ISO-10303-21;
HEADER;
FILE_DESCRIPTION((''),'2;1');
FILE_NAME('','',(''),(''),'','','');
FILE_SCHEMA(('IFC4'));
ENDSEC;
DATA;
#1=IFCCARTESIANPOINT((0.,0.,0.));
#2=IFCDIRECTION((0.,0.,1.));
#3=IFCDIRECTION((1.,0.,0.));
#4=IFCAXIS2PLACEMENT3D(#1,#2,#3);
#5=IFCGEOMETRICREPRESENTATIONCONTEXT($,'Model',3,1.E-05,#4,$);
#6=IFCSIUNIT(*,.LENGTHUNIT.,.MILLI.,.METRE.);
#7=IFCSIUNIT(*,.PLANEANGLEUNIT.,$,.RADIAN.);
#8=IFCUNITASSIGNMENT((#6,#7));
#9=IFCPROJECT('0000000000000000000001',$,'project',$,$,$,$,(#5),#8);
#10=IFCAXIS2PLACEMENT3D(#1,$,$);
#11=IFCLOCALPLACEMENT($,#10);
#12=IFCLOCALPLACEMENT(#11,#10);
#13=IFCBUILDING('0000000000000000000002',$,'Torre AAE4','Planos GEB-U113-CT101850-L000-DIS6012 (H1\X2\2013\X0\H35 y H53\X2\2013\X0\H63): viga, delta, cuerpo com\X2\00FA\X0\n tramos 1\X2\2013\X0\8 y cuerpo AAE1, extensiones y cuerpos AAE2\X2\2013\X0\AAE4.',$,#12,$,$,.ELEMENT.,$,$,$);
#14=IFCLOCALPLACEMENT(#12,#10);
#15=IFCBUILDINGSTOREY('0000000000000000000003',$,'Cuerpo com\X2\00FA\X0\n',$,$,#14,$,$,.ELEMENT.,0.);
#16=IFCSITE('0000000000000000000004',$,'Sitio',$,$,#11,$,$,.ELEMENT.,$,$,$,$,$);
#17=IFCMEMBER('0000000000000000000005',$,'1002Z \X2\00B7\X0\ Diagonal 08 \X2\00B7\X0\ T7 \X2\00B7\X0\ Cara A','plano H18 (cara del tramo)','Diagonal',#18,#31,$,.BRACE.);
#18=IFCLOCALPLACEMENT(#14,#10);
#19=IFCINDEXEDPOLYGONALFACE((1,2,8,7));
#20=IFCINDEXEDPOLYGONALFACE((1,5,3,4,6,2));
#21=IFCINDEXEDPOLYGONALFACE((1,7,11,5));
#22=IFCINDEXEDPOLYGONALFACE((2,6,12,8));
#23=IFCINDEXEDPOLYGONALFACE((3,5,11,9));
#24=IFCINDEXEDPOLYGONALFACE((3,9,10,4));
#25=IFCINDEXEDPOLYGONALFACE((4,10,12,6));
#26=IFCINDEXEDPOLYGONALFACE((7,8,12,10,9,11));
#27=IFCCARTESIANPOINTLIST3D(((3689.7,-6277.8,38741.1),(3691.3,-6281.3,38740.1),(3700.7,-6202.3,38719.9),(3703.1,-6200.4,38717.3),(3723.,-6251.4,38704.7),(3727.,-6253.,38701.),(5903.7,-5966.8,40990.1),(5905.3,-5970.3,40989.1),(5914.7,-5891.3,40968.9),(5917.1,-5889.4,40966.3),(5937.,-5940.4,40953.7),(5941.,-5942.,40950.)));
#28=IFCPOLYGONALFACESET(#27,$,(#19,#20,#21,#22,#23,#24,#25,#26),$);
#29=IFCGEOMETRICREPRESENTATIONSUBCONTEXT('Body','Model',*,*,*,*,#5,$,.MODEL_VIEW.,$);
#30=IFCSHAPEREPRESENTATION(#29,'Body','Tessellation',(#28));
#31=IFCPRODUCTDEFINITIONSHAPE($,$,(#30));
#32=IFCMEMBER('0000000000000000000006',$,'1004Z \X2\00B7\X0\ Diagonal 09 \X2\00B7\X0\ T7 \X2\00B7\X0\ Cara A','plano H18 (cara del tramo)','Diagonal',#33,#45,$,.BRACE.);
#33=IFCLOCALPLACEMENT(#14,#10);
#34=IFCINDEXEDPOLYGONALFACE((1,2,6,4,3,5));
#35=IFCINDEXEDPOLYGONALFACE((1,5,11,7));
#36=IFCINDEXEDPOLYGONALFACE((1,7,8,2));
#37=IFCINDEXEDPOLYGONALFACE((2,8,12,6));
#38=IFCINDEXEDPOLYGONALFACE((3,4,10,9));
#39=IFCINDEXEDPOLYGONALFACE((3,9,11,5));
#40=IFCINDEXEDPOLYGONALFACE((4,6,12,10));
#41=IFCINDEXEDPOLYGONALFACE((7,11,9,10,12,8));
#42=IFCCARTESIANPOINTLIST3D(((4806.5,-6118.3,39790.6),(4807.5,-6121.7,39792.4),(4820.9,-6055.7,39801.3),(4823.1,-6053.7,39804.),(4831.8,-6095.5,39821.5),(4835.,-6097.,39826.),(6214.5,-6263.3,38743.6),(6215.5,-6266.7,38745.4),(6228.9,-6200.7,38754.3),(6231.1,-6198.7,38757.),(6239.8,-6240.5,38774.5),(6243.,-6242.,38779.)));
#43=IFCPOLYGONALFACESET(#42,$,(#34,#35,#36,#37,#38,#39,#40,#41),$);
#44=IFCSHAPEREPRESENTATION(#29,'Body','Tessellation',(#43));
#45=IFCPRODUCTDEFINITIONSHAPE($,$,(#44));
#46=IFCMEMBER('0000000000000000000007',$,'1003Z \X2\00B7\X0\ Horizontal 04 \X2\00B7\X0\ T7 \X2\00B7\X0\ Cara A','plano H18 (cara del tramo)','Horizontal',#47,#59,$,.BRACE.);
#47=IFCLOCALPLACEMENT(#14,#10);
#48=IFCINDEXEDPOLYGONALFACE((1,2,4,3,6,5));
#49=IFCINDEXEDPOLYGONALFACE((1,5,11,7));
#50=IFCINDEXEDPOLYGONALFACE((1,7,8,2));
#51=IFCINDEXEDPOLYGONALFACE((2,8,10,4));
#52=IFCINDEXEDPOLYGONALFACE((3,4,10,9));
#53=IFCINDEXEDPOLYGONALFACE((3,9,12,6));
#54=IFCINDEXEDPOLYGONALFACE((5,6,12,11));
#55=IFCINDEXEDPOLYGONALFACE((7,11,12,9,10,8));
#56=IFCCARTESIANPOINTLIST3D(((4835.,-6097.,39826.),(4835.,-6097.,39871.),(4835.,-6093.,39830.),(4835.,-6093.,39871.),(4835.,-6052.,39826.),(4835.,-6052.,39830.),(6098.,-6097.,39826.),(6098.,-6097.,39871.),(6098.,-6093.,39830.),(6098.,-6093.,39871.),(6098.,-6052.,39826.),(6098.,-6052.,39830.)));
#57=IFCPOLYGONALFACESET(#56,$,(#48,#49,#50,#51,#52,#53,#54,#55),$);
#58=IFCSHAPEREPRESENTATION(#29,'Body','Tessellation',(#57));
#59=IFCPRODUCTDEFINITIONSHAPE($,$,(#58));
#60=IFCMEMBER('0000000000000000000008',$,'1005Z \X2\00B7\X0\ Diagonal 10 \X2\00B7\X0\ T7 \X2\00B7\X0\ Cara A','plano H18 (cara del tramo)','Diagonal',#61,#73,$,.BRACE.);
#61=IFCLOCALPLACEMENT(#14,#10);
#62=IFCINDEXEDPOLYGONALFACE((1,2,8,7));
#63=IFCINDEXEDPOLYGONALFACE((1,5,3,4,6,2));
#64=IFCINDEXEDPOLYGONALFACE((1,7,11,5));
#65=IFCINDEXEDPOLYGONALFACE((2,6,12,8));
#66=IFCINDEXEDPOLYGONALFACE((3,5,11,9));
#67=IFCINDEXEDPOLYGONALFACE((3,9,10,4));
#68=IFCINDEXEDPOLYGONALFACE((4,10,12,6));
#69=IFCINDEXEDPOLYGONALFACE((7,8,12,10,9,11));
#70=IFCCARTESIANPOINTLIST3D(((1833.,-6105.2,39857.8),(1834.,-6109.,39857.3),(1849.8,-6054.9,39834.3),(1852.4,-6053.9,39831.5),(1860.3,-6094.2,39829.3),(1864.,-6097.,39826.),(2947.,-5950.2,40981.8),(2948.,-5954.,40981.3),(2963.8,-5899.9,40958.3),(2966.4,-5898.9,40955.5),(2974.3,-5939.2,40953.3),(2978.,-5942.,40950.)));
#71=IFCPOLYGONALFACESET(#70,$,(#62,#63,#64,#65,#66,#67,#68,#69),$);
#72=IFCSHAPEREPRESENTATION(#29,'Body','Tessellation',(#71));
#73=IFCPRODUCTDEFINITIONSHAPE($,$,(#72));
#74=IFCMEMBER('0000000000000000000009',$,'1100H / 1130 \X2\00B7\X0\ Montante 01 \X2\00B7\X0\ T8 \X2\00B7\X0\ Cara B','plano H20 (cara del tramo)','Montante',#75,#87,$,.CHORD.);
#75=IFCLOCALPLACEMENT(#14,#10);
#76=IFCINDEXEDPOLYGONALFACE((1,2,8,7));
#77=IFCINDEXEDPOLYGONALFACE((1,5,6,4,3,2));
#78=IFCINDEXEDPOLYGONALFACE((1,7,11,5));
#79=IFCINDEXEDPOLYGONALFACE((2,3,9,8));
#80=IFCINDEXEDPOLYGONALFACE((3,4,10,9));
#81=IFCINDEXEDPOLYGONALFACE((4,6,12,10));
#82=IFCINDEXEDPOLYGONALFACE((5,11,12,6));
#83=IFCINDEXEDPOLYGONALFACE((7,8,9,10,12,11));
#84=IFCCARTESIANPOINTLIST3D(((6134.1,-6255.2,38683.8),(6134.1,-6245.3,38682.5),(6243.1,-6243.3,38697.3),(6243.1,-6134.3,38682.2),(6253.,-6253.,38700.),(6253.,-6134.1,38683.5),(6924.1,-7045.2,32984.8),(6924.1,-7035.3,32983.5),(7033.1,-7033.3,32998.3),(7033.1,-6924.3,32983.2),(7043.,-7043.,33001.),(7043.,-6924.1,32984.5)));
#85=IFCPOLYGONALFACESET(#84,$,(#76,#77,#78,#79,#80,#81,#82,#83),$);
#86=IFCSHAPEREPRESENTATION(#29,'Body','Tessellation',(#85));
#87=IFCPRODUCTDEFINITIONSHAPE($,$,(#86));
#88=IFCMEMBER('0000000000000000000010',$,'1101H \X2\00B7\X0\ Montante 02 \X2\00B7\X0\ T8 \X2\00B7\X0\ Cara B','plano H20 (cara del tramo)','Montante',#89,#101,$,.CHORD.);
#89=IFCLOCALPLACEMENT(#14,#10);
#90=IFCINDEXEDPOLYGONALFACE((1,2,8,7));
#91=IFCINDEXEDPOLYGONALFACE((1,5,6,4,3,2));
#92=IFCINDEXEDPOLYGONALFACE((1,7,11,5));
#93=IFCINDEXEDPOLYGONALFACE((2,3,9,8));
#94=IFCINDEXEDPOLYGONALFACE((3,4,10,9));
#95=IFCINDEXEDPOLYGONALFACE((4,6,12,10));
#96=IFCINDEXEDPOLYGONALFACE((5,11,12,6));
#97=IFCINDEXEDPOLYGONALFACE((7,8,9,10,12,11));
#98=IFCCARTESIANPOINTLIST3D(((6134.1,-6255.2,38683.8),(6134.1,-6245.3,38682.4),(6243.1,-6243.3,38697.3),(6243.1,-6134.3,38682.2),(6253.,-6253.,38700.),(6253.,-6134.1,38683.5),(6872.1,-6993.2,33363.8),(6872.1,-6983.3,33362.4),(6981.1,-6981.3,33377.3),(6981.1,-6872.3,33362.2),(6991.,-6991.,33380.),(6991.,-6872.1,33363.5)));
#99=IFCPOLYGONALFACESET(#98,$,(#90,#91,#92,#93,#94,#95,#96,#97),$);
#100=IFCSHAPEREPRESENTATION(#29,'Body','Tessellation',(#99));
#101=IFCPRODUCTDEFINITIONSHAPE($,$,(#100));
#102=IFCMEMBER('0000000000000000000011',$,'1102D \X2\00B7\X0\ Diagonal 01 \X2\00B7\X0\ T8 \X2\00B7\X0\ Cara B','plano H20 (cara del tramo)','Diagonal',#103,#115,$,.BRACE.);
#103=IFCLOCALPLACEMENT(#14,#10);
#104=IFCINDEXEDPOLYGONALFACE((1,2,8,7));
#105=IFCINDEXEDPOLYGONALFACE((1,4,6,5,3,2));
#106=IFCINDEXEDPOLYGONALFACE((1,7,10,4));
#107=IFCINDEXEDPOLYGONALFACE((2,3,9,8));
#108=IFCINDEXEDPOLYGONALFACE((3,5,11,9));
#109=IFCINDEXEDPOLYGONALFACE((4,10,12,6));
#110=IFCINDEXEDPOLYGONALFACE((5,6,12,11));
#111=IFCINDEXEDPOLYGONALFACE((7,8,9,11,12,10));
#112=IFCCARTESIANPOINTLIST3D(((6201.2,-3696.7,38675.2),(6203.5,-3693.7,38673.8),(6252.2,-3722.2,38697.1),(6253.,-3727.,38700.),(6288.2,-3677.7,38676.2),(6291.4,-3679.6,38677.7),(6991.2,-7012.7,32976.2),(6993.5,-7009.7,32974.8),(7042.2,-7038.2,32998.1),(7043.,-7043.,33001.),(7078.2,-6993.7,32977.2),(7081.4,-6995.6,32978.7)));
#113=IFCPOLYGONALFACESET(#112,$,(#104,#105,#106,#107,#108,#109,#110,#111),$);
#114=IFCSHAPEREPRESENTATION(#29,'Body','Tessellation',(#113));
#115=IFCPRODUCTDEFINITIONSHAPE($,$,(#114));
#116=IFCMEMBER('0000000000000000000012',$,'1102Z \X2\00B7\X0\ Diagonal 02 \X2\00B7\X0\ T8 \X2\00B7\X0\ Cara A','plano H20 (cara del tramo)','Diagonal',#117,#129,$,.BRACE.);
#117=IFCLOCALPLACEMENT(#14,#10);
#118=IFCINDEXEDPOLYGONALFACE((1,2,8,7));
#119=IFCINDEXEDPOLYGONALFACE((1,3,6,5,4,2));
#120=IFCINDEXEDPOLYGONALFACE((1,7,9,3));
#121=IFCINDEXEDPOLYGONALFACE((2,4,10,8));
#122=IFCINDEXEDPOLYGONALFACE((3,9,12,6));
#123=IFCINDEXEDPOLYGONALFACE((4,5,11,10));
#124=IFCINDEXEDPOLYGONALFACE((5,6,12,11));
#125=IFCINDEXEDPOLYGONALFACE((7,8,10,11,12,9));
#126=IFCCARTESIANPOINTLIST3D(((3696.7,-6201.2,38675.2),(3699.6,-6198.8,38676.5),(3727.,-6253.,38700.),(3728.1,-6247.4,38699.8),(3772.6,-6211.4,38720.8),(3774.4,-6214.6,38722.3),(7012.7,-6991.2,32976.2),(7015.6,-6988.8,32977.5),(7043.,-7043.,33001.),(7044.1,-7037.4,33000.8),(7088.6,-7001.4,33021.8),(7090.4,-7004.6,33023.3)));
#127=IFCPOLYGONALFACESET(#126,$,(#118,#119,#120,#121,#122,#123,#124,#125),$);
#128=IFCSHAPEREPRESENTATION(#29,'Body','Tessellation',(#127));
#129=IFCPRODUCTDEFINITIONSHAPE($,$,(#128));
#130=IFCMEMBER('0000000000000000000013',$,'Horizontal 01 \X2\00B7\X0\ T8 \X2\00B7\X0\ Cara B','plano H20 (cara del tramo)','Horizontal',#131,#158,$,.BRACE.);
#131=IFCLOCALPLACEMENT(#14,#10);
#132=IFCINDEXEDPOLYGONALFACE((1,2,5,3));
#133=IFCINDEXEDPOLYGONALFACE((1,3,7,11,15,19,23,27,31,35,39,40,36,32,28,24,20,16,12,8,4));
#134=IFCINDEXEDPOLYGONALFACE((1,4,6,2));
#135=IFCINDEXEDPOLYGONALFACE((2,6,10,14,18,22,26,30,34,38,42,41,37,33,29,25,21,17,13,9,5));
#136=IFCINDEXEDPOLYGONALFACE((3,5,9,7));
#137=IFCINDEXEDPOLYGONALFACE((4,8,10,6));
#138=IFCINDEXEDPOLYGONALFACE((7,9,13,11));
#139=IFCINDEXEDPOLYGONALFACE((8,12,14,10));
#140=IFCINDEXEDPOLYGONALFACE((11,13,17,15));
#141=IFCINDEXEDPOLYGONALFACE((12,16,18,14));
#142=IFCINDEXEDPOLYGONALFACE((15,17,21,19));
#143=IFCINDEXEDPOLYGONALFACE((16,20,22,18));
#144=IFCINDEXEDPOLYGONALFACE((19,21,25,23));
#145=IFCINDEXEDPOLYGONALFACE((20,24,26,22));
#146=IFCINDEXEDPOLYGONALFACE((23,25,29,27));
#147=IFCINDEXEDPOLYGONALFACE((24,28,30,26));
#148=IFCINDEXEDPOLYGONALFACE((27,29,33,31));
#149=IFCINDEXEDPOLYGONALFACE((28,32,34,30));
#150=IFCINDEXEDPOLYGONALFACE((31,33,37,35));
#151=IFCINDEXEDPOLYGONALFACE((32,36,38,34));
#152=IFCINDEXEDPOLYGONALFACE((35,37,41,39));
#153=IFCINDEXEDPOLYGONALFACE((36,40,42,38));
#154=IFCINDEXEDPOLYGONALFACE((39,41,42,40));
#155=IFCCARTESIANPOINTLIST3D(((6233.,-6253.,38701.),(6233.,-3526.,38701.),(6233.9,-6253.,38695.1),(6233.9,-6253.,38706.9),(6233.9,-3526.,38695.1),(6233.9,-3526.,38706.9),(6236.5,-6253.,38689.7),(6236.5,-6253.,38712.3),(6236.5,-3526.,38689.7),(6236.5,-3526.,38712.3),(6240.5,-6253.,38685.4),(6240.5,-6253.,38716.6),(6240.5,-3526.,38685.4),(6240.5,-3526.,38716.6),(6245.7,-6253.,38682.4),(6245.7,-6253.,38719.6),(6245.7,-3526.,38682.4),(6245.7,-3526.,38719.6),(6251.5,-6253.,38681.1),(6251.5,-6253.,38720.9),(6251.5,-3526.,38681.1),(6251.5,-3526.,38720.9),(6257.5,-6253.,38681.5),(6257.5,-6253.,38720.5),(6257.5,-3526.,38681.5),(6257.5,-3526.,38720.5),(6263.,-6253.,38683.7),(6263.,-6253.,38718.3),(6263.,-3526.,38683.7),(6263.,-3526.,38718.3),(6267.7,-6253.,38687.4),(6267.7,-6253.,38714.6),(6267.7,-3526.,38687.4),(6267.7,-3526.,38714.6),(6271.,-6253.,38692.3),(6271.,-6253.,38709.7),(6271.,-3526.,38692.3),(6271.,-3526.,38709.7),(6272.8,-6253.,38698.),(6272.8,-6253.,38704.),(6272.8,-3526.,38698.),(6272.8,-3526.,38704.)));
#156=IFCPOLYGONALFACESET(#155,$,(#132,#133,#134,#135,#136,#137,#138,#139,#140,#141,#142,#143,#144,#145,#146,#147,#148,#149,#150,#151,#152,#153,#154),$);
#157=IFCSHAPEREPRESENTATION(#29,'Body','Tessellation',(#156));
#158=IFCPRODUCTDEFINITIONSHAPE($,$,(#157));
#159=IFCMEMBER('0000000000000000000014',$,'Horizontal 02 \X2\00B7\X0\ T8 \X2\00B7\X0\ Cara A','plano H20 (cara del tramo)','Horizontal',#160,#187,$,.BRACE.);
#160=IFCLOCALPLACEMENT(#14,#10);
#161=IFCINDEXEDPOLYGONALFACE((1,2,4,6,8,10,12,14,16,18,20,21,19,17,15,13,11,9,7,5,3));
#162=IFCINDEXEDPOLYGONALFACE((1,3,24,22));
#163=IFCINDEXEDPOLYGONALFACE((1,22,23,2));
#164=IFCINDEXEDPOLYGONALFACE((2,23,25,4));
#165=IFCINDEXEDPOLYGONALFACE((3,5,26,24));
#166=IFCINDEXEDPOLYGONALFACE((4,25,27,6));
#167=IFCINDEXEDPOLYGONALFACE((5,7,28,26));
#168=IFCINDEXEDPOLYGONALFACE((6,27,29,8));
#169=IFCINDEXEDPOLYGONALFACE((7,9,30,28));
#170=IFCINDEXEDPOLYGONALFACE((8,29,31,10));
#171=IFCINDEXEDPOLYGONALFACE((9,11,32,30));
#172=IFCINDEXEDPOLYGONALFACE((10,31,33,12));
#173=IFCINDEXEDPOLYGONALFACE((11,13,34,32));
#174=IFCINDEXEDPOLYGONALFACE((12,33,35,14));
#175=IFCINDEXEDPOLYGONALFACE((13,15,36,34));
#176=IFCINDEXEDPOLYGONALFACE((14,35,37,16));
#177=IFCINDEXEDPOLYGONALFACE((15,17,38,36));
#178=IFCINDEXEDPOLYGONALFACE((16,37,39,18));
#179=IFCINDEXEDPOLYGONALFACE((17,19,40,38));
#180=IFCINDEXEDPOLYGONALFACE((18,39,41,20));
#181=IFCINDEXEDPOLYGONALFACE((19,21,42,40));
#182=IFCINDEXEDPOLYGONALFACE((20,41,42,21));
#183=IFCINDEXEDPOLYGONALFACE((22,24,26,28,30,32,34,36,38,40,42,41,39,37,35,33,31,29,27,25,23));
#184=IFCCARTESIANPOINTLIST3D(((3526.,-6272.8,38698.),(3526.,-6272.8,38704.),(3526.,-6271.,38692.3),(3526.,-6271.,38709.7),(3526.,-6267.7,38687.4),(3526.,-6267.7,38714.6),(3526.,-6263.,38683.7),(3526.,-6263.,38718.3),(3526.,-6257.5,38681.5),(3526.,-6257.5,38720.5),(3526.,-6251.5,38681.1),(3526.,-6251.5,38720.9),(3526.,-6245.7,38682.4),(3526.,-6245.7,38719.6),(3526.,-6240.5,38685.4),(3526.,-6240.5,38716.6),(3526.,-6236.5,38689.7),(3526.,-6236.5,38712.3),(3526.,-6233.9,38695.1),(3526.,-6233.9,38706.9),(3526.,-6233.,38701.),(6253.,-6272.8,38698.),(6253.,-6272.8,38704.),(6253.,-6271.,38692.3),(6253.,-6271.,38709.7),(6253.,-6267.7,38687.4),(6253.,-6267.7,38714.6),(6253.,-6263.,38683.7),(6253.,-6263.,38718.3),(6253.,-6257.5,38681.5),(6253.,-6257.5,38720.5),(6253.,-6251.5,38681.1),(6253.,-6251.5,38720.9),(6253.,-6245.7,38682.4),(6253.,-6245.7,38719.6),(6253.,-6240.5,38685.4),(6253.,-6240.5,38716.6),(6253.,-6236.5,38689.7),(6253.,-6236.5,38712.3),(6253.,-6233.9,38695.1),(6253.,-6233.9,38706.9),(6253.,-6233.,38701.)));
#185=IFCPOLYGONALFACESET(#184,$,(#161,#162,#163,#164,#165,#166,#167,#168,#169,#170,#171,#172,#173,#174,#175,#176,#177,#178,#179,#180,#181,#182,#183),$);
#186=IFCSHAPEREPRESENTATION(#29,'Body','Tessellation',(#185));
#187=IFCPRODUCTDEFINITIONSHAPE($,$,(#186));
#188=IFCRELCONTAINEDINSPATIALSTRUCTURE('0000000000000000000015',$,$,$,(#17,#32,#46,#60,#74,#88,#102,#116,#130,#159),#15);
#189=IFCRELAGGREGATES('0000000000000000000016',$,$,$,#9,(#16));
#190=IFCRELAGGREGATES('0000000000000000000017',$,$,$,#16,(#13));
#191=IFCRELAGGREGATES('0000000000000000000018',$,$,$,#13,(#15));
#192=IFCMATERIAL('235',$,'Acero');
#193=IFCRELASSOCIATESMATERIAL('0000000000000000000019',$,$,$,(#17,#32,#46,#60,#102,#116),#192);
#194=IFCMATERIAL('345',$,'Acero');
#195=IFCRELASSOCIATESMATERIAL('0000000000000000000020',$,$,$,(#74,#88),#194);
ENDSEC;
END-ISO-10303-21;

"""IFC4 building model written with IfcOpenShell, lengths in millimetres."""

from ifc_helpers import new_model, si_unit, frame, frame_2d, origin, origin_with_axes, place, context, subcontext, project, spatial, circle, l_section, extrude, material, element, save


model = new_model("IFC4")

# Units and contexts
model_context = context("Model", 3, precision=1e-05, world=origin_with_axes())
body_context = subcontext(model_context, "Body", "Model", "MODEL_VIEW")
ifc_project = project(units=[si_unit("LENGTHUNIT", "METRE", prefix="MILLI"), si_unit("PLANEANGLEUNIT", "RADIAN")], contexts=[model_context])

# Site, building, storey
site_placement = place(None, origin())
site = spatial("IfcSite", under=ifc_project, at=site_placement, Name="Sitio", CompositionType="ELEMENT")
building_placement = place(site_placement, origin())
building = spatial("IfcBuilding", under=site, at=building_placement, Name="Torre AAE4", Description="Planos GEB-U113-CT101850-L000-DIS6012 (H1–H35 y H53–H63): viga, delta, cuerpo común tramos 1–8 y cuerpo AAE1, extensiones y cuerpos AAE2–AAE4.", CompositionType="ELEMENT")
storey_placement = place(building_placement, origin())
storey = spatial("IfcBuildingStorey", under=building, at=storey_placement, Name="Cuerpo común", CompositionType="ELEMENT", Elevation=0.0)

# Members
ifc_material_1 = material(Name="235", Category="Acero")
ifc_material_2 = material(Name="345", Category="Acero")
member_1_placement = place(storey_placement, frame((3727.0, -6253.0, 38701.0), z_axis=(0.698158, 0.09807, 0.709195), x_axis=(-0.398314, 0.876322, 0.270934)))
element("IfcMember", 1, at=member_1_placement, inside=storey, material=ifc_material_1, Name="1002Z · Diagonal 08 · T7 · Cara A", Description="plano H18 (cara del tramo)", ObjectType="Diagonal", PredefinedType="BRACE", context=body_context, shape_type="SweptSolid", body=[
    extrude(l_section(Depth=60.0, Width=60.0, Thickness=4.0, at=frame_2d((30.0, 30.0))), None, (0.0, 0.0, 1.0), 3171.2),
])
member_2_placement = place(storey_placement, frame((6243.0, -6242.0, 38779.0), z_axis=(-0.799729, 0.082358, 0.594685), x_axis=(-0.238737, 0.865234, -0.440879)))
element("IfcMember", 2, at=member_2_placement, inside=storey, material=ifc_material_1, Name="1004Z · Diagonal 09 · T7 · Cara A", Description="plano H18 (cara del tramo)", ObjectType="Diagonal", PredefinedType="BRACE", context=body_context, shape_type="SweptSolid", body=[
    extrude(l_section(Depth=50.0, Width=50.0, Thickness=4.0, at=frame_2d((25.0, 25.0))), None, (0.0, 0.0, 1.0), 1760.6),
])
member_3_placement = place(storey_placement, frame((4835.0, -6097.0, 39826.0), z_axis=(1.0, 0.0, 0.0), x_axis=(0.0, 1.0, 0.0)))
element("IfcMember", 3, at=member_3_placement, inside=storey, material=ifc_material_1, Name="1003Z · Horizontal 04 · T7 · Cara A", Description="plano H18 (cara del tramo)", ObjectType="Horizontal", PredefinedType="BRACE", context=body_context, shape_type="SweptSolid", body=[
    extrude(l_section(Depth=45.0, Width=45.0, Thickness=4.0, at=frame_2d((22.5, 22.5))), None, (0.0, 0.0, 1.0), 1263.0),
])
member_4_placement = place(storey_placement, frame((1864.0, -6097.0, 39826.0), z_axis=(0.700588, 0.097479, 0.706877), x_axis=(-0.257143, 0.958556, 0.12267)))
element("IfcMember", 4, at=member_4_placement, inside=storey, material=ifc_material_1, Name="1005Z · Diagonal 10 · T7 · Cara A", Description="plano H18 (cara del tramo)", ObjectType="Diagonal", PredefinedType="BRACE", context=body_context, shape_type="SweptSolid", body=[
    extrude(l_section(Depth=45.0, Width=45.0, Thickness=4.0, at=frame_2d((22.5, 22.5))), None, (0.0, 0.0, 1.0), 1590.1),
])
member_5_placement = place(storey_placement, frame((6253.0, -6253.0, 38700.0), z_axis=(0.136032, -0.136032, -0.981321), x_axis=(-0.990705, -0.018678, -0.134743)))
element("IfcMember", 5, at=member_5_placement, inside=storey, material=ifc_material_2, Name="1100H / 1130 · Montante 01 · T8 · Cara B", Description="plano H20 (cara del tramo)", ObjectType="Montante", PredefinedType="CHORD", context=body_context, shape_type="SweptSolid", body=[
    extrude(l_section(Depth=120.0, Width=120.0, Thickness=10.0, at=frame_2d((60.0, 60.0))), None, (0.0, 0.0, 1.0), 5807.5),
])
member_6_placement = place(storey_placement, frame((6253.0, -6253.0, 38700.0), z_axis=(0.136127, -0.136127, -0.981295), x_axis=(-0.990691, -0.018705, -0.134836)))
element("IfcMember", 6, at=member_6_placement, inside=storey, material=ifc_material_2, Name="1101H · Montante 02 · T8 · Cara B", Description="plano H20 (cara del tramo)", ObjectType="Montante", PredefinedType="CHORD", context=body_context, shape_type="SweptSolid", body=[
    extrude(l_section(Depth=120.0, Width=120.0, Thickness=10.0, at=frame_2d((60.0, 60.0))), None, (0.0, 0.0, 1.0), 5421.4),
])
for number, where, z_axis, x_axis, name in (
    (7, (6253.0, -3727.0, 38700.0), (0.118964, -0.499347, -0.858196), (-0.797631, 0.466671, -0.382104), "1102D · Diagonal 01 · T8 · Cara B"),
    (8, (3727.0, -6253.0, 38700.0), (0.499347, -0.118964, -0.858196), (-0.466671, 0.797631, -0.382104), "1102Z · Diagonal 02 · T8 · Cara A"),
):
    element("IfcMember", number, at=place(storey_placement, frame(where, z_axis=z_axis, x_axis=x_axis)), inside=storey, material=ifc_material_1, Name=name, Description="plano H20 (cara del tramo)", ObjectType="Diagonal", PredefinedType="BRACE", context=body_context, shape_type="SweptSolid", body=[
        extrude(l_section(Depth=65.0, Width=65.0, Thickness=4.0, at=frame_2d((32.5, 32.5))), None, (0.0, 0.0, 1.0), 6640.7),
    ])
for number, where, z_axis, x_axis, name in (
    (9, (6253.0, -6253.0, 38701.0), (0.0, 1.0, 0.0), (-1.0, 0.0, 0.0), "Horizontal 01 · T8 · Cara B"),
    (10, (6253.0, -6253.0, 38701.0), (-1.0, 0.0, 0.0), (0.0, 1.0, 0.0), "Horizontal 02 · T8 · Cara A"),
):
    element("IfcMember", number, at=place(storey_placement, frame(where, z_axis=z_axis, x_axis=x_axis)), inside=storey, Name=name, Description="plano H20 (cara del tramo)", ObjectType="Horizontal", PredefinedType="BRACE", context=body_context, shape_type="SweptSolid", body=[
        extrude(circle(Radius=20.0), None, (0.0, 0.0, 1.0), 2727.0),
    ])

save(model, "model.ifc")
